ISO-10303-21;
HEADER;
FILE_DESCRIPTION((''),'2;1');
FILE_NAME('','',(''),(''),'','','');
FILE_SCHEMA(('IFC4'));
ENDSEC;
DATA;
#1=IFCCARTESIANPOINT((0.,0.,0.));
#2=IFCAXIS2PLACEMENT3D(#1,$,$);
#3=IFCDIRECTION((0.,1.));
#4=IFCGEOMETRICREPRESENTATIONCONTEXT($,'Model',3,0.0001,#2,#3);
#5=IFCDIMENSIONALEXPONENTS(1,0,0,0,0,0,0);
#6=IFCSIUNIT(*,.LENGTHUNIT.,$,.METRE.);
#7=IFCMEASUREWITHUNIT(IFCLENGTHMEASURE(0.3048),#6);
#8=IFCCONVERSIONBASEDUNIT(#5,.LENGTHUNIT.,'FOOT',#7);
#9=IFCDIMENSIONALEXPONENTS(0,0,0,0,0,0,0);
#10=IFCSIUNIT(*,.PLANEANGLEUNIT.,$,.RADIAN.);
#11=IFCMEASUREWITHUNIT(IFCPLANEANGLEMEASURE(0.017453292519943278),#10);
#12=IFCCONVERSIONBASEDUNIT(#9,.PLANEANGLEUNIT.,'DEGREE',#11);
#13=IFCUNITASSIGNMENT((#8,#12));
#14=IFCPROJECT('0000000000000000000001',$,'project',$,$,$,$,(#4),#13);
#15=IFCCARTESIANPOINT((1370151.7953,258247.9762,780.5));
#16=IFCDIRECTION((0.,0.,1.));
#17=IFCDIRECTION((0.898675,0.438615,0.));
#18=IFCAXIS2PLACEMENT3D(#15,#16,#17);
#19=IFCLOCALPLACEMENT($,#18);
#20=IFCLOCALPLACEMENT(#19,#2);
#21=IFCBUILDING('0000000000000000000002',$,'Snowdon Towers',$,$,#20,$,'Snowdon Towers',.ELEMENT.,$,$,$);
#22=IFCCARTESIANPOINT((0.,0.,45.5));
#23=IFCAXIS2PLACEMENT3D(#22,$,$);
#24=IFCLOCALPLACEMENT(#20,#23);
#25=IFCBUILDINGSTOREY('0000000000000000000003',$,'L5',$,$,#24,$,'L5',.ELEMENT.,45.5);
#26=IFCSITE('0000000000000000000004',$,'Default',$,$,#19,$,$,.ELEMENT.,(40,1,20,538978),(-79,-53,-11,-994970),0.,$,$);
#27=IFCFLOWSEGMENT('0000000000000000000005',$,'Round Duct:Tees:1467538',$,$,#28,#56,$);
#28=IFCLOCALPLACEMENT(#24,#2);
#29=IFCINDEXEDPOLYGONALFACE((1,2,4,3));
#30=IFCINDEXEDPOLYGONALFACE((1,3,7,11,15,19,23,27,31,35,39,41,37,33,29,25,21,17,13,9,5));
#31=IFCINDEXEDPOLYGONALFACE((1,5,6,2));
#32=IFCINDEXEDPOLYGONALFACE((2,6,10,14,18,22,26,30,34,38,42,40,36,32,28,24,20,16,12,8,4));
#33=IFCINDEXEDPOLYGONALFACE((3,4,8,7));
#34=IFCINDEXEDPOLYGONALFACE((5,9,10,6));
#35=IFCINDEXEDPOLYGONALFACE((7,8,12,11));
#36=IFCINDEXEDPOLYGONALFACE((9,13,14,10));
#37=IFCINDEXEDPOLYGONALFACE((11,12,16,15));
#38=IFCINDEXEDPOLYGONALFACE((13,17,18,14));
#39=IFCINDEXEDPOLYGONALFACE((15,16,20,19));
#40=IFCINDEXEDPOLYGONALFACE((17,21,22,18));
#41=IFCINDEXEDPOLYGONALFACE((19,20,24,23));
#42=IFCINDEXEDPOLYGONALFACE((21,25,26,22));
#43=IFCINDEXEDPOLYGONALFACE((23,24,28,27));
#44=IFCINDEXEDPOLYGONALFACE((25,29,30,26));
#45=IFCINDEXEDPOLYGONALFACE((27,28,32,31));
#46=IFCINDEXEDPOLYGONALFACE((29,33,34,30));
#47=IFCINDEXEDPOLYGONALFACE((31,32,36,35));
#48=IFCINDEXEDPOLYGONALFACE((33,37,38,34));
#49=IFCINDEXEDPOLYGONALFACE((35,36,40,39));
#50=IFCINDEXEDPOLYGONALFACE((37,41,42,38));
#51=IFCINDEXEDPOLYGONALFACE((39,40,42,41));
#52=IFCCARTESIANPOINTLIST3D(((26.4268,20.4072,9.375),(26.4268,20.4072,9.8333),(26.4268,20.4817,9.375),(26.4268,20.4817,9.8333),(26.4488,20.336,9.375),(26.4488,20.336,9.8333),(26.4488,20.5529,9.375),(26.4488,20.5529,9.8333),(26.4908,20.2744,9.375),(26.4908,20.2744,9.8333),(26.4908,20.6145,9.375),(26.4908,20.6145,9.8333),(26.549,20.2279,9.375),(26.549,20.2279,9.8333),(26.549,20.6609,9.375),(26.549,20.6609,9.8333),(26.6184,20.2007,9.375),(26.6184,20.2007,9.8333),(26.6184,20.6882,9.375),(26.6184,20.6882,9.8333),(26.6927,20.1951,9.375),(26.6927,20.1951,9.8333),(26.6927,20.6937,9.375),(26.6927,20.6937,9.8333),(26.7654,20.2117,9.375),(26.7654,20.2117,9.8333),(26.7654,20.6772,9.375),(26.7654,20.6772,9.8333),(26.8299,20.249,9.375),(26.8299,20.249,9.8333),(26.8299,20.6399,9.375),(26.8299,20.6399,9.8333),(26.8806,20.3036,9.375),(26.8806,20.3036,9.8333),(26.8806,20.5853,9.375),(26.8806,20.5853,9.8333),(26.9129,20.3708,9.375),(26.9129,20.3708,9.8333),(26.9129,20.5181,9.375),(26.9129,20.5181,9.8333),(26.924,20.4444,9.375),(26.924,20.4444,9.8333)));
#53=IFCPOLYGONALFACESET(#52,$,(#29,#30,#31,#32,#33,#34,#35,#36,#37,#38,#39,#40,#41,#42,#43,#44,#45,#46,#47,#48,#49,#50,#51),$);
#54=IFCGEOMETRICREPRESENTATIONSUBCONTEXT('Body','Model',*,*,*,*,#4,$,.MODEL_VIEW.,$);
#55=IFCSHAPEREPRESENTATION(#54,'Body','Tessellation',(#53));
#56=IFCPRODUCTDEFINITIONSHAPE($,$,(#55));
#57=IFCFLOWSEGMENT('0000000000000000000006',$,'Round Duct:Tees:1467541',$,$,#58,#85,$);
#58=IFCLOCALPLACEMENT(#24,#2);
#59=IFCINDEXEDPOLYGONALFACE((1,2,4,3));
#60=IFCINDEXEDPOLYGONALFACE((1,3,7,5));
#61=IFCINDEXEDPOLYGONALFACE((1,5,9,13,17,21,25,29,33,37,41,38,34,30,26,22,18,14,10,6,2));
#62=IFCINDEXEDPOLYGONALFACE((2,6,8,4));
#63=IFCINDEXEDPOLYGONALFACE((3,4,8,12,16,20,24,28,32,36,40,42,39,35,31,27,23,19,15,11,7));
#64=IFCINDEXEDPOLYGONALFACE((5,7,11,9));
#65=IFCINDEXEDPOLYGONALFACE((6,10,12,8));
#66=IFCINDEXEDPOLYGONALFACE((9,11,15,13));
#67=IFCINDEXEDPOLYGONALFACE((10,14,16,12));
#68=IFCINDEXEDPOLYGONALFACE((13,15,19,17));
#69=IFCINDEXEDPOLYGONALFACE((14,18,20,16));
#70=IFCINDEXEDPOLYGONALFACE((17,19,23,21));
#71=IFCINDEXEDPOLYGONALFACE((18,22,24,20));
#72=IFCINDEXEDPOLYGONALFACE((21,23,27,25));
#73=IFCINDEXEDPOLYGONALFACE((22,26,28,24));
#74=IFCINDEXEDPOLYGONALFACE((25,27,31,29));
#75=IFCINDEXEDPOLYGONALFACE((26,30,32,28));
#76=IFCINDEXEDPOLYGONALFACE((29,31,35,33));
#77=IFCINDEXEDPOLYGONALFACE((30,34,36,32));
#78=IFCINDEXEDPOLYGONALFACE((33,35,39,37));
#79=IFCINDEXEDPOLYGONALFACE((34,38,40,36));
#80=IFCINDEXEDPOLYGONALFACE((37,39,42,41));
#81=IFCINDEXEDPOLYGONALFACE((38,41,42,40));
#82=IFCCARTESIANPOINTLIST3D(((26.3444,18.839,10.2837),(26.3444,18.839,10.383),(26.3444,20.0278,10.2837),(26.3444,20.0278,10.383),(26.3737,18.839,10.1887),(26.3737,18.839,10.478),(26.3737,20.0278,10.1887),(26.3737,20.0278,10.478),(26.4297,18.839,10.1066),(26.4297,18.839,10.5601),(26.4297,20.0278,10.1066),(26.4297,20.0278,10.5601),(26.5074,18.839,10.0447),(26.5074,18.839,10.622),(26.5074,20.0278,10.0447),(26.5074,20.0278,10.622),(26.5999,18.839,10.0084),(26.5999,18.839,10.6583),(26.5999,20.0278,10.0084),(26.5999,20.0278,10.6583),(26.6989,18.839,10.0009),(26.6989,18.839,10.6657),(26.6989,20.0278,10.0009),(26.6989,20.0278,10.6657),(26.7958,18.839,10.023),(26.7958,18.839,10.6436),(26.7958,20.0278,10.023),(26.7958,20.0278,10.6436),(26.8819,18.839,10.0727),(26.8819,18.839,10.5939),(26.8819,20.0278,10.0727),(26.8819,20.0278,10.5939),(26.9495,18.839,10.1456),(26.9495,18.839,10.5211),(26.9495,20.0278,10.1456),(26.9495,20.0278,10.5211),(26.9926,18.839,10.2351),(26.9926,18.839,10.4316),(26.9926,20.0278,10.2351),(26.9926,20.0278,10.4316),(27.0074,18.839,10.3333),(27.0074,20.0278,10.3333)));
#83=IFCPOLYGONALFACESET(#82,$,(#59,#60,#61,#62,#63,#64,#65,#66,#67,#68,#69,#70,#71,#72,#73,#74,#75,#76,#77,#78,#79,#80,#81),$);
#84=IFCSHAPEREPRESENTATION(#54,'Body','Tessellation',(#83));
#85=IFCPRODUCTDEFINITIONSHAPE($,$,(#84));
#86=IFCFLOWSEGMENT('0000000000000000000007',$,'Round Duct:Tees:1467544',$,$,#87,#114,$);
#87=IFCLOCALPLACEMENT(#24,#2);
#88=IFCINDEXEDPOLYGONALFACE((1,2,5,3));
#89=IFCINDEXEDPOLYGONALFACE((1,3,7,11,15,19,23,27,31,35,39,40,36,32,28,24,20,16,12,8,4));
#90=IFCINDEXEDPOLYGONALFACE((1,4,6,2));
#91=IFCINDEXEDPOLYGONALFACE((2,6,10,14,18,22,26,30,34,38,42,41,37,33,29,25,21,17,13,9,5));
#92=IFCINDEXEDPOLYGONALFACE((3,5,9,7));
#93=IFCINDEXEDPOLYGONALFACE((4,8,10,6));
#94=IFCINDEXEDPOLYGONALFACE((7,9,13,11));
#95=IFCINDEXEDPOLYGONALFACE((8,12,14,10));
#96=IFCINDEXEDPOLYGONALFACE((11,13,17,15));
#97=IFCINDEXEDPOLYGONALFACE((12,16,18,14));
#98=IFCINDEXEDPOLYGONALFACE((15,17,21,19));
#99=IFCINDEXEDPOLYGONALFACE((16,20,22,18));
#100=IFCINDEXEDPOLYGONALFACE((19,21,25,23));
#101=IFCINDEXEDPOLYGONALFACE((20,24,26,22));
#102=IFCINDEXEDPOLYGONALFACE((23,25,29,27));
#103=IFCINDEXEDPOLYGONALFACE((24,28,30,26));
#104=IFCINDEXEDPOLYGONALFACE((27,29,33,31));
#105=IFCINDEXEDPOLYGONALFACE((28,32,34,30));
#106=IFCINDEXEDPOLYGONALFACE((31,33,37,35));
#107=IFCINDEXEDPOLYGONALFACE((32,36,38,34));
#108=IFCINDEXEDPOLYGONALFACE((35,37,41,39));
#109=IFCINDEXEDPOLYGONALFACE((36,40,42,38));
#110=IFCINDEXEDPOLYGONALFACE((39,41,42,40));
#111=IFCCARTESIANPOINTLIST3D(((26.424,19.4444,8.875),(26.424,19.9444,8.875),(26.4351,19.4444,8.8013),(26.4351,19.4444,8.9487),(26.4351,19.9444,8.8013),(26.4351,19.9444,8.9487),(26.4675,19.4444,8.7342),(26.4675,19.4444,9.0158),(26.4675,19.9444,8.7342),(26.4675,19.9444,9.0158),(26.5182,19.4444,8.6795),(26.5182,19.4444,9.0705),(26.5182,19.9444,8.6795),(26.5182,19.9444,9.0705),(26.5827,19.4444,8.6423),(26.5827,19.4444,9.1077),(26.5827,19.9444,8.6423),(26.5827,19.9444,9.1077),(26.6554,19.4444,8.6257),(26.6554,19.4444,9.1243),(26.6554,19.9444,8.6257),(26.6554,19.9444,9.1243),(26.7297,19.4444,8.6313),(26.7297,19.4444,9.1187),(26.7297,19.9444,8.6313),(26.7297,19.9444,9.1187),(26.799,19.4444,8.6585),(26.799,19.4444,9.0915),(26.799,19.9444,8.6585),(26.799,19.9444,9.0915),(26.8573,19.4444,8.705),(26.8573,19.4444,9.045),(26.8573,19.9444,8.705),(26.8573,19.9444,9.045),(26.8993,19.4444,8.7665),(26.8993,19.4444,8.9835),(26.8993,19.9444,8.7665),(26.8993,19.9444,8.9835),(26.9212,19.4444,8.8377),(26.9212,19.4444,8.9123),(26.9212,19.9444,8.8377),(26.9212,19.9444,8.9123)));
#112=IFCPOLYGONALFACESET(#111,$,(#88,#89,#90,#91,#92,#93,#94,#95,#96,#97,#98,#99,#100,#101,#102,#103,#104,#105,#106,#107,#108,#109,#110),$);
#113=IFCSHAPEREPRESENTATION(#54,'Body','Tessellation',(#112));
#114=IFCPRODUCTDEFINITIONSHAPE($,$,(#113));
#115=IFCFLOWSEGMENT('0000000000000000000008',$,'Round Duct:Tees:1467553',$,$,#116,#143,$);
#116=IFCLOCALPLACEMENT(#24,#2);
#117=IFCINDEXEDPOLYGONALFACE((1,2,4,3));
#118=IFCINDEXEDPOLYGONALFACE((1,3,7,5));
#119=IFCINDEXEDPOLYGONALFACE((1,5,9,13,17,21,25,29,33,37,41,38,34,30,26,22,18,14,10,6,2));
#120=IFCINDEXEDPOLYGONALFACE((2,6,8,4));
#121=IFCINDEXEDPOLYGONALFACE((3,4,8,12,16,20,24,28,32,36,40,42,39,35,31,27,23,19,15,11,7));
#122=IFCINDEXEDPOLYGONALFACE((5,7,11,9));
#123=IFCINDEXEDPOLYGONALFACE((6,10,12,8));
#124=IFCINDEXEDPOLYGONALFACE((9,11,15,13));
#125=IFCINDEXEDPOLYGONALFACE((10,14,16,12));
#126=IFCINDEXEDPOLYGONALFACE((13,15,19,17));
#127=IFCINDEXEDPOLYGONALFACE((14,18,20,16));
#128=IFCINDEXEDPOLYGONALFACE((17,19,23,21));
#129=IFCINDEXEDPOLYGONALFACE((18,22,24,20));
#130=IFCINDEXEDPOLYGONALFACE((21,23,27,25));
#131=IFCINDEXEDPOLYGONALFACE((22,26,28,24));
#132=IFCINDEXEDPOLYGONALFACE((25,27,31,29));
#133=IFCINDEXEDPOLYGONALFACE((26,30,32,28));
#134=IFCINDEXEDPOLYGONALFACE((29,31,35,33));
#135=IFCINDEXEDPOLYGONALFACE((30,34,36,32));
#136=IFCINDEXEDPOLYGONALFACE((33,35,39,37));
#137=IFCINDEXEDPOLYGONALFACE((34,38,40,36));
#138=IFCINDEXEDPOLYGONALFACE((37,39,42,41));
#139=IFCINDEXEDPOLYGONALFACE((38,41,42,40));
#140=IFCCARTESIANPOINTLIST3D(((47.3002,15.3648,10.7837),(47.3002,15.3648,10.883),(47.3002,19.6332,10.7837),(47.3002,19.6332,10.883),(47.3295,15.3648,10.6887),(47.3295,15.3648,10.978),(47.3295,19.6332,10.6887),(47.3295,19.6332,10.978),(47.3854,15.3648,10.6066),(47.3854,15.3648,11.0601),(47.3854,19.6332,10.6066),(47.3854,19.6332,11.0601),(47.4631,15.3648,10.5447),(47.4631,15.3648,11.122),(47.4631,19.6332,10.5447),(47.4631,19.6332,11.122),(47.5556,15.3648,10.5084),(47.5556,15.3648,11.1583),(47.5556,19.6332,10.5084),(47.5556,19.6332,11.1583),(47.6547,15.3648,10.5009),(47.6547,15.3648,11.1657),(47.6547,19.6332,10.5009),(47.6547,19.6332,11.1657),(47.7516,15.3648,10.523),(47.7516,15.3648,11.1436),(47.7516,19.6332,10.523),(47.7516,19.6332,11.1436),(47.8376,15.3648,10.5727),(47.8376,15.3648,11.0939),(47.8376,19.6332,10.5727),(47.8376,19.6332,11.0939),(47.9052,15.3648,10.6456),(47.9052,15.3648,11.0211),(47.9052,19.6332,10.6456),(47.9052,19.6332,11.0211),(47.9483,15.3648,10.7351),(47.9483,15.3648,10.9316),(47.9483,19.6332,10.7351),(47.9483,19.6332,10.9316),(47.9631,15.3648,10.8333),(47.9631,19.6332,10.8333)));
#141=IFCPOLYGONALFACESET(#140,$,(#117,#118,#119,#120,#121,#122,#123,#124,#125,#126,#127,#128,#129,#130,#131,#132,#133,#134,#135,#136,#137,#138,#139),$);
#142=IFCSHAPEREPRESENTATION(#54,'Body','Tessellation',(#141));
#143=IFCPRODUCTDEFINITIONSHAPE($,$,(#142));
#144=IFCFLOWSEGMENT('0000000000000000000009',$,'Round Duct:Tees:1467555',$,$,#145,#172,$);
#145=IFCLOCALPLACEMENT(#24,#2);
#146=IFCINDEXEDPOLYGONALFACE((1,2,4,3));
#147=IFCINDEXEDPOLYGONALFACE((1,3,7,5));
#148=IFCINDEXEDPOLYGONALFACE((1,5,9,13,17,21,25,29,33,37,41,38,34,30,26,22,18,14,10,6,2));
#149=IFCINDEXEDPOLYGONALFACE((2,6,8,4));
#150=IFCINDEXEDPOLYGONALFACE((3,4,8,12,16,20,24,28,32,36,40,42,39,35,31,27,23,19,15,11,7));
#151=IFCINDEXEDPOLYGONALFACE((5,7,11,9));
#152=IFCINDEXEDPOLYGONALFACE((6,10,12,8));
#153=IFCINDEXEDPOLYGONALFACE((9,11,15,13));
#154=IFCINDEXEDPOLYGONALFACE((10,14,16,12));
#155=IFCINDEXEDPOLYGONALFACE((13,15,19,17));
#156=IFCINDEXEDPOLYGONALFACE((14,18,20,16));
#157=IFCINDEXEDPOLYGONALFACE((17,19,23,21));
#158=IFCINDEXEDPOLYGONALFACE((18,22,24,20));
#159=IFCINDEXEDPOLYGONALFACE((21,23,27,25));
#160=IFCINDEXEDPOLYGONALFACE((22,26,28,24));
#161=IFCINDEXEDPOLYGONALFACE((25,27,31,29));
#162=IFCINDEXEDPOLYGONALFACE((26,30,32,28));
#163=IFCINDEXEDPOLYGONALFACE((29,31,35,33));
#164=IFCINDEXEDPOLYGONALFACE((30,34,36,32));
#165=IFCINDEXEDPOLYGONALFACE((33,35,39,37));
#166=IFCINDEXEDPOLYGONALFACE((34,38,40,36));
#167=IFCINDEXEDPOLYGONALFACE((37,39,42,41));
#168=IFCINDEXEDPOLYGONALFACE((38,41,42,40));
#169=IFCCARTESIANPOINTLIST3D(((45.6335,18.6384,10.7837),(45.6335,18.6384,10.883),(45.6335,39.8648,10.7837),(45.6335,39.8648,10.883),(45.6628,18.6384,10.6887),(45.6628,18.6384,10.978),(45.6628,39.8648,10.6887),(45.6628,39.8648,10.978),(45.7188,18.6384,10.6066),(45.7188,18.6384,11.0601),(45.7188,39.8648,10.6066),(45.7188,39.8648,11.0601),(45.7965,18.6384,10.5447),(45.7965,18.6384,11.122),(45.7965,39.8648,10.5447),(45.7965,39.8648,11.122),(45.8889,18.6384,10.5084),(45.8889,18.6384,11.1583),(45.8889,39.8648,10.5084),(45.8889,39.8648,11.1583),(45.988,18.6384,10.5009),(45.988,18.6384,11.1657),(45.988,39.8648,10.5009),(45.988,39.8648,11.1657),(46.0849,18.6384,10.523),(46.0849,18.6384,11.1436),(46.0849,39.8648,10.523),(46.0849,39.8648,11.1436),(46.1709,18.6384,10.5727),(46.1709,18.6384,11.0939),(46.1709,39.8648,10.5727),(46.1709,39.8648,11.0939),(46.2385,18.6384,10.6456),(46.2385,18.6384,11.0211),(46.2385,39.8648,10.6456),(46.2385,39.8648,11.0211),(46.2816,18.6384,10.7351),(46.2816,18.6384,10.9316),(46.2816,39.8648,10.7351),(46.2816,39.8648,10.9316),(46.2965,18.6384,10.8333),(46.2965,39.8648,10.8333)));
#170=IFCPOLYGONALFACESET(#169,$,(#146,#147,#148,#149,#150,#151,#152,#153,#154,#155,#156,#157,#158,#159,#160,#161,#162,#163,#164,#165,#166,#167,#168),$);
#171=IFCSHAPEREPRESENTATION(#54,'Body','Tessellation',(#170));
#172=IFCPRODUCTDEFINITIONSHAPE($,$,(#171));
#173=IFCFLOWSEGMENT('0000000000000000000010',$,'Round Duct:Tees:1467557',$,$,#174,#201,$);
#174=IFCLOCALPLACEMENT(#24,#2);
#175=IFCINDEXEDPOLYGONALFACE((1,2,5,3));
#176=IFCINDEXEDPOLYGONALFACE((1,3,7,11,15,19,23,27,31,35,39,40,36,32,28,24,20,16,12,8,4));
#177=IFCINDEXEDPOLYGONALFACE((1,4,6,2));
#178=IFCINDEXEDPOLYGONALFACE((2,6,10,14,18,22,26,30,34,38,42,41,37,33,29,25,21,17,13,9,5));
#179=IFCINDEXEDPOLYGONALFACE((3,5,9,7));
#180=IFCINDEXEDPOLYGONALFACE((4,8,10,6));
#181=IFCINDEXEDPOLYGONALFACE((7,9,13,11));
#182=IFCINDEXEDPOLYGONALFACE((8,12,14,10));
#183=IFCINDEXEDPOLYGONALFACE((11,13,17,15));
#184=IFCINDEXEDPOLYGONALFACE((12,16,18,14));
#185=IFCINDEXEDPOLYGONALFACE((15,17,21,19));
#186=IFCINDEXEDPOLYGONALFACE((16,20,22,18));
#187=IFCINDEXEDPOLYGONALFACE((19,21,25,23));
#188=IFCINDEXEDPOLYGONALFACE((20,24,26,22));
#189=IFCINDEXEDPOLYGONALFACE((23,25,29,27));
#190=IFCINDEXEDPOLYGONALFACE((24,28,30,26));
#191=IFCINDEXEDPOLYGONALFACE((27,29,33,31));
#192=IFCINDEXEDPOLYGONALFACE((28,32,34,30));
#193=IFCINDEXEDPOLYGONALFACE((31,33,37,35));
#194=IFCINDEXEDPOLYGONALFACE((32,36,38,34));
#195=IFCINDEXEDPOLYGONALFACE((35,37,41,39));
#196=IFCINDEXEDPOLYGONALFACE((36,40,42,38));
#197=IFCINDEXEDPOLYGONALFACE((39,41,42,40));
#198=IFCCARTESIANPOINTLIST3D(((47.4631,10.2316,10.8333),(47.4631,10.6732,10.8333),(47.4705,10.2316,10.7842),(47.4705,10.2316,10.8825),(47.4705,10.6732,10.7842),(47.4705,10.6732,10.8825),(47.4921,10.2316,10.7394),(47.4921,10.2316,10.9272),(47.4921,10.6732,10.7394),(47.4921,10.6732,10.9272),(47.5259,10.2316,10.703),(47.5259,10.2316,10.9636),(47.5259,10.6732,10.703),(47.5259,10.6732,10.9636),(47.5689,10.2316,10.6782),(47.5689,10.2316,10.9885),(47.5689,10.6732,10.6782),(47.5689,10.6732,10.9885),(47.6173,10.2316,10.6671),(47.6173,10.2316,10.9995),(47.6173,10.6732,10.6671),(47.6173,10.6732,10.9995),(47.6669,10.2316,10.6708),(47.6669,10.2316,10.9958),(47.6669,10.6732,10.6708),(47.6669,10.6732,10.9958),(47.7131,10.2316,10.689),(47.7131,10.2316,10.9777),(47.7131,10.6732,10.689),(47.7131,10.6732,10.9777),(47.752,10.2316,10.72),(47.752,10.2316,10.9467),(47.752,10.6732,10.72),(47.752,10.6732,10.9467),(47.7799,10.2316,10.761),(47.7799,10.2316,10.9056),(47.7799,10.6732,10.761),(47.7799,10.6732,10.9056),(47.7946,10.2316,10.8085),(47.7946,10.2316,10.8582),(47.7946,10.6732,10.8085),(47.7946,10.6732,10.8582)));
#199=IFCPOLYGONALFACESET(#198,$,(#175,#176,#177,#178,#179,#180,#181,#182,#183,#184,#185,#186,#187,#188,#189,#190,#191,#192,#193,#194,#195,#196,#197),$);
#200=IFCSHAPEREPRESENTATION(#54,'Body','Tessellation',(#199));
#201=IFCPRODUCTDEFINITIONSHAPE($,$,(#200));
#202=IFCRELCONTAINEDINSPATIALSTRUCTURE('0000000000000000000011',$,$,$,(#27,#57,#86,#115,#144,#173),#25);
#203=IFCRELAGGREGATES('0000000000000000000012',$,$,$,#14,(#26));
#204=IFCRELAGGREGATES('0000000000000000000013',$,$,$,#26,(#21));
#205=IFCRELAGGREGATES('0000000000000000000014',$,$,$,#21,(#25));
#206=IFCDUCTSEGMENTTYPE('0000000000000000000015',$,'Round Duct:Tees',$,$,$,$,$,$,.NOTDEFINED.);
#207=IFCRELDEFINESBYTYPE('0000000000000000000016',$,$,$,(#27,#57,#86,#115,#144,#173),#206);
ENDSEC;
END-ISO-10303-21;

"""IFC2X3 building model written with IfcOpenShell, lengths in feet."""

from ifc_helpers import new_model, entity, si_unit, converted_unit, direction, frame, frame_2d, origin, origin_2d_with_axis, place, context, subcontext, project, spatial, circle, extrude, type_object, element, save


model = new_model("IFC2X3")

# Units and contexts
model_context = context("Model", 3, precision=0.0001, world=origin(), true_north=direction((0.0, 1.0)))
body_context = subcontext(model_context, "Body", "Model", "MODEL_VIEW")
ifc_project = project(units=[converted_unit("LENGTHUNIT", "FOOT", entity("IfcLengthMeasure", 0.3048), si_unit("LENGTHUNIT", "METRE"), dimensions=[1, 0, 0, 0, 0, 0, 0]), converted_unit("PLANEANGLEUNIT", "DEGREE", entity("IfcPlaneAngleMeasure", 0.017453292519943278), si_unit("PLANEANGLEUNIT", "RADIAN"), dimensions=[0, 0, 0, 0, 0, 0, 0])], contexts=[model_context])

# Site, building, storey
site_placement = place(None, frame((1370151.7953, 258247.9762, 780.5), z_axis=(0.0, 0.0, 1.0), x_axis=(0.898675, 0.438615, 0.0)))
site = spatial("IfcSite", under=ifc_project, at=site_placement, Name="Default", CompositionType="ELEMENT", RefLatitude=(40, 1, 20, 538978), RefLongitude=(-79, -53, -11, -994970), RefElevation=0.0)
building_placement = place(site_placement, origin())
building = spatial("IfcBuilding", under=site, at=building_placement, Name="Snowdon Towers", LongName="Snowdon Towers", CompositionType="ELEMENT")
storey_placement = place(building_placement, frame((0.0, 0.0, 45.5)))
storey = spatial("IfcBuildingStorey", under=building, at=storey_placement, Name="L5", LongName="L5", CompositionType="ELEMENT", Elevation=45.5)

# Flow segments
duct_segment_type = type_object("IfcDuctSegmentType", Name="Round Duct:Tees", PredefinedType="NOTDEFINED")
flow_segment_1_placement = place(storey_placement, origin())
element("IfcFlowSegment", 1, at=flow_segment_1_placement, inside=storey, type_object=duct_segment_type, Name="Round Duct:Tees:1467538", context=body_context, shape_type="SweptSolid", body=[
    extrude(circle(Radius=0.25, at=frame_2d((0.0, 0.0), x_axis=(1.0, 0.0))), frame((26.674, 20.4444, 9.375)), (0.0, 0.0, 1.0), 0.4583),
])
flow_segment_2_placement = place(storey_placement, origin())
element("IfcFlowSegment", 2, at=flow_segment_2_placement, inside=storey, type_object=duct_segment_type, Name="Round Duct:Tees:1467541", context=body_context, shape_type="SweptSolid", body=[
    extrude(circle(Radius=0.3333, at=origin_2d_with_axis()), frame((26.674, 18.839, 10.3333), z_axis=(0.0, 1.0, 0.0), x_axis=(1.0, 0.0, 0.0)), (0.0, 0.0, 1.0), 1.1887),
])
flow_segment_3_placement = place(storey_placement, origin())
element("IfcFlowSegment", 3, at=flow_segment_3_placement, inside=storey, type_object=duct_segment_type, Name="Round Duct:Tees:1467544", context=body_context, shape_type="SweptSolid", body=[
    extrude(circle(Radius=0.25, at=frame_2d((0.0, 0.0), x_axis=(1.0, 0.0))), frame((26.674, 19.4444, 8.875), z_axis=(0.0, 1.0, 0.0), x_axis=(-1.0, 0.0, 0.0)), (0.0, 0.0, 1.0), 0.5),
])
flow_segment_4_placement = place(storey_placement, origin())
element("IfcFlowSegment", 4, at=flow_segment_4_placement, inside=storey, type_object=duct_segment_type, Name="Round Duct:Tees:1467553", context=body_context, shape_type="SweptSolid", body=[
    extrude(circle(Radius=0.3333, at=frame_2d((0.0, 0.0), x_axis=(1.0, 0.0))), frame((47.6298, 15.3648, 10.8333), z_axis=(0.0, 1.0, 0.0), x_axis=(1.0, 0.0, 0.0)), (0.0, 0.0, 1.0), 4.2684),
])
flow_segment_5_placement = place(storey_placement, origin())
element("IfcFlowSegment", 5, at=flow_segment_5_placement, inside=storey, type_object=duct_segment_type, Name="Round Duct:Tees:1467555", context=body_context, shape_type="SweptSolid", body=[
    extrude(circle(Radius=0.3333, at=frame_2d((0.0, 0.0), x_axis=(1.0, 0.0))), frame((45.9631, 18.6384, 10.8333), z_axis=(0.0, 1.0, 0.0), x_axis=(1.0, 0.0, 0.0)), (0.0, 0.0, 1.0), 21.2264),
])
flow_segment_6_placement = place(storey_placement, origin())
element("IfcFlowSegment", 6, at=flow_segment_6_placement, inside=storey, type_object=duct_segment_type, Name="Round Duct:Tees:1467557", context=body_context, shape_type="SweptSolid", body=[
    extrude(circle(Radius=0.1667, at=origin_2d_with_axis()), frame((47.6298, 10.2316, 10.8333), z_axis=(0.0, 1.0, 0.0), x_axis=(-1.0, 0.0, 0.0)), (0.0, 0.0, 1.0), 0.4416),
])

save(model, "model.ifc")
